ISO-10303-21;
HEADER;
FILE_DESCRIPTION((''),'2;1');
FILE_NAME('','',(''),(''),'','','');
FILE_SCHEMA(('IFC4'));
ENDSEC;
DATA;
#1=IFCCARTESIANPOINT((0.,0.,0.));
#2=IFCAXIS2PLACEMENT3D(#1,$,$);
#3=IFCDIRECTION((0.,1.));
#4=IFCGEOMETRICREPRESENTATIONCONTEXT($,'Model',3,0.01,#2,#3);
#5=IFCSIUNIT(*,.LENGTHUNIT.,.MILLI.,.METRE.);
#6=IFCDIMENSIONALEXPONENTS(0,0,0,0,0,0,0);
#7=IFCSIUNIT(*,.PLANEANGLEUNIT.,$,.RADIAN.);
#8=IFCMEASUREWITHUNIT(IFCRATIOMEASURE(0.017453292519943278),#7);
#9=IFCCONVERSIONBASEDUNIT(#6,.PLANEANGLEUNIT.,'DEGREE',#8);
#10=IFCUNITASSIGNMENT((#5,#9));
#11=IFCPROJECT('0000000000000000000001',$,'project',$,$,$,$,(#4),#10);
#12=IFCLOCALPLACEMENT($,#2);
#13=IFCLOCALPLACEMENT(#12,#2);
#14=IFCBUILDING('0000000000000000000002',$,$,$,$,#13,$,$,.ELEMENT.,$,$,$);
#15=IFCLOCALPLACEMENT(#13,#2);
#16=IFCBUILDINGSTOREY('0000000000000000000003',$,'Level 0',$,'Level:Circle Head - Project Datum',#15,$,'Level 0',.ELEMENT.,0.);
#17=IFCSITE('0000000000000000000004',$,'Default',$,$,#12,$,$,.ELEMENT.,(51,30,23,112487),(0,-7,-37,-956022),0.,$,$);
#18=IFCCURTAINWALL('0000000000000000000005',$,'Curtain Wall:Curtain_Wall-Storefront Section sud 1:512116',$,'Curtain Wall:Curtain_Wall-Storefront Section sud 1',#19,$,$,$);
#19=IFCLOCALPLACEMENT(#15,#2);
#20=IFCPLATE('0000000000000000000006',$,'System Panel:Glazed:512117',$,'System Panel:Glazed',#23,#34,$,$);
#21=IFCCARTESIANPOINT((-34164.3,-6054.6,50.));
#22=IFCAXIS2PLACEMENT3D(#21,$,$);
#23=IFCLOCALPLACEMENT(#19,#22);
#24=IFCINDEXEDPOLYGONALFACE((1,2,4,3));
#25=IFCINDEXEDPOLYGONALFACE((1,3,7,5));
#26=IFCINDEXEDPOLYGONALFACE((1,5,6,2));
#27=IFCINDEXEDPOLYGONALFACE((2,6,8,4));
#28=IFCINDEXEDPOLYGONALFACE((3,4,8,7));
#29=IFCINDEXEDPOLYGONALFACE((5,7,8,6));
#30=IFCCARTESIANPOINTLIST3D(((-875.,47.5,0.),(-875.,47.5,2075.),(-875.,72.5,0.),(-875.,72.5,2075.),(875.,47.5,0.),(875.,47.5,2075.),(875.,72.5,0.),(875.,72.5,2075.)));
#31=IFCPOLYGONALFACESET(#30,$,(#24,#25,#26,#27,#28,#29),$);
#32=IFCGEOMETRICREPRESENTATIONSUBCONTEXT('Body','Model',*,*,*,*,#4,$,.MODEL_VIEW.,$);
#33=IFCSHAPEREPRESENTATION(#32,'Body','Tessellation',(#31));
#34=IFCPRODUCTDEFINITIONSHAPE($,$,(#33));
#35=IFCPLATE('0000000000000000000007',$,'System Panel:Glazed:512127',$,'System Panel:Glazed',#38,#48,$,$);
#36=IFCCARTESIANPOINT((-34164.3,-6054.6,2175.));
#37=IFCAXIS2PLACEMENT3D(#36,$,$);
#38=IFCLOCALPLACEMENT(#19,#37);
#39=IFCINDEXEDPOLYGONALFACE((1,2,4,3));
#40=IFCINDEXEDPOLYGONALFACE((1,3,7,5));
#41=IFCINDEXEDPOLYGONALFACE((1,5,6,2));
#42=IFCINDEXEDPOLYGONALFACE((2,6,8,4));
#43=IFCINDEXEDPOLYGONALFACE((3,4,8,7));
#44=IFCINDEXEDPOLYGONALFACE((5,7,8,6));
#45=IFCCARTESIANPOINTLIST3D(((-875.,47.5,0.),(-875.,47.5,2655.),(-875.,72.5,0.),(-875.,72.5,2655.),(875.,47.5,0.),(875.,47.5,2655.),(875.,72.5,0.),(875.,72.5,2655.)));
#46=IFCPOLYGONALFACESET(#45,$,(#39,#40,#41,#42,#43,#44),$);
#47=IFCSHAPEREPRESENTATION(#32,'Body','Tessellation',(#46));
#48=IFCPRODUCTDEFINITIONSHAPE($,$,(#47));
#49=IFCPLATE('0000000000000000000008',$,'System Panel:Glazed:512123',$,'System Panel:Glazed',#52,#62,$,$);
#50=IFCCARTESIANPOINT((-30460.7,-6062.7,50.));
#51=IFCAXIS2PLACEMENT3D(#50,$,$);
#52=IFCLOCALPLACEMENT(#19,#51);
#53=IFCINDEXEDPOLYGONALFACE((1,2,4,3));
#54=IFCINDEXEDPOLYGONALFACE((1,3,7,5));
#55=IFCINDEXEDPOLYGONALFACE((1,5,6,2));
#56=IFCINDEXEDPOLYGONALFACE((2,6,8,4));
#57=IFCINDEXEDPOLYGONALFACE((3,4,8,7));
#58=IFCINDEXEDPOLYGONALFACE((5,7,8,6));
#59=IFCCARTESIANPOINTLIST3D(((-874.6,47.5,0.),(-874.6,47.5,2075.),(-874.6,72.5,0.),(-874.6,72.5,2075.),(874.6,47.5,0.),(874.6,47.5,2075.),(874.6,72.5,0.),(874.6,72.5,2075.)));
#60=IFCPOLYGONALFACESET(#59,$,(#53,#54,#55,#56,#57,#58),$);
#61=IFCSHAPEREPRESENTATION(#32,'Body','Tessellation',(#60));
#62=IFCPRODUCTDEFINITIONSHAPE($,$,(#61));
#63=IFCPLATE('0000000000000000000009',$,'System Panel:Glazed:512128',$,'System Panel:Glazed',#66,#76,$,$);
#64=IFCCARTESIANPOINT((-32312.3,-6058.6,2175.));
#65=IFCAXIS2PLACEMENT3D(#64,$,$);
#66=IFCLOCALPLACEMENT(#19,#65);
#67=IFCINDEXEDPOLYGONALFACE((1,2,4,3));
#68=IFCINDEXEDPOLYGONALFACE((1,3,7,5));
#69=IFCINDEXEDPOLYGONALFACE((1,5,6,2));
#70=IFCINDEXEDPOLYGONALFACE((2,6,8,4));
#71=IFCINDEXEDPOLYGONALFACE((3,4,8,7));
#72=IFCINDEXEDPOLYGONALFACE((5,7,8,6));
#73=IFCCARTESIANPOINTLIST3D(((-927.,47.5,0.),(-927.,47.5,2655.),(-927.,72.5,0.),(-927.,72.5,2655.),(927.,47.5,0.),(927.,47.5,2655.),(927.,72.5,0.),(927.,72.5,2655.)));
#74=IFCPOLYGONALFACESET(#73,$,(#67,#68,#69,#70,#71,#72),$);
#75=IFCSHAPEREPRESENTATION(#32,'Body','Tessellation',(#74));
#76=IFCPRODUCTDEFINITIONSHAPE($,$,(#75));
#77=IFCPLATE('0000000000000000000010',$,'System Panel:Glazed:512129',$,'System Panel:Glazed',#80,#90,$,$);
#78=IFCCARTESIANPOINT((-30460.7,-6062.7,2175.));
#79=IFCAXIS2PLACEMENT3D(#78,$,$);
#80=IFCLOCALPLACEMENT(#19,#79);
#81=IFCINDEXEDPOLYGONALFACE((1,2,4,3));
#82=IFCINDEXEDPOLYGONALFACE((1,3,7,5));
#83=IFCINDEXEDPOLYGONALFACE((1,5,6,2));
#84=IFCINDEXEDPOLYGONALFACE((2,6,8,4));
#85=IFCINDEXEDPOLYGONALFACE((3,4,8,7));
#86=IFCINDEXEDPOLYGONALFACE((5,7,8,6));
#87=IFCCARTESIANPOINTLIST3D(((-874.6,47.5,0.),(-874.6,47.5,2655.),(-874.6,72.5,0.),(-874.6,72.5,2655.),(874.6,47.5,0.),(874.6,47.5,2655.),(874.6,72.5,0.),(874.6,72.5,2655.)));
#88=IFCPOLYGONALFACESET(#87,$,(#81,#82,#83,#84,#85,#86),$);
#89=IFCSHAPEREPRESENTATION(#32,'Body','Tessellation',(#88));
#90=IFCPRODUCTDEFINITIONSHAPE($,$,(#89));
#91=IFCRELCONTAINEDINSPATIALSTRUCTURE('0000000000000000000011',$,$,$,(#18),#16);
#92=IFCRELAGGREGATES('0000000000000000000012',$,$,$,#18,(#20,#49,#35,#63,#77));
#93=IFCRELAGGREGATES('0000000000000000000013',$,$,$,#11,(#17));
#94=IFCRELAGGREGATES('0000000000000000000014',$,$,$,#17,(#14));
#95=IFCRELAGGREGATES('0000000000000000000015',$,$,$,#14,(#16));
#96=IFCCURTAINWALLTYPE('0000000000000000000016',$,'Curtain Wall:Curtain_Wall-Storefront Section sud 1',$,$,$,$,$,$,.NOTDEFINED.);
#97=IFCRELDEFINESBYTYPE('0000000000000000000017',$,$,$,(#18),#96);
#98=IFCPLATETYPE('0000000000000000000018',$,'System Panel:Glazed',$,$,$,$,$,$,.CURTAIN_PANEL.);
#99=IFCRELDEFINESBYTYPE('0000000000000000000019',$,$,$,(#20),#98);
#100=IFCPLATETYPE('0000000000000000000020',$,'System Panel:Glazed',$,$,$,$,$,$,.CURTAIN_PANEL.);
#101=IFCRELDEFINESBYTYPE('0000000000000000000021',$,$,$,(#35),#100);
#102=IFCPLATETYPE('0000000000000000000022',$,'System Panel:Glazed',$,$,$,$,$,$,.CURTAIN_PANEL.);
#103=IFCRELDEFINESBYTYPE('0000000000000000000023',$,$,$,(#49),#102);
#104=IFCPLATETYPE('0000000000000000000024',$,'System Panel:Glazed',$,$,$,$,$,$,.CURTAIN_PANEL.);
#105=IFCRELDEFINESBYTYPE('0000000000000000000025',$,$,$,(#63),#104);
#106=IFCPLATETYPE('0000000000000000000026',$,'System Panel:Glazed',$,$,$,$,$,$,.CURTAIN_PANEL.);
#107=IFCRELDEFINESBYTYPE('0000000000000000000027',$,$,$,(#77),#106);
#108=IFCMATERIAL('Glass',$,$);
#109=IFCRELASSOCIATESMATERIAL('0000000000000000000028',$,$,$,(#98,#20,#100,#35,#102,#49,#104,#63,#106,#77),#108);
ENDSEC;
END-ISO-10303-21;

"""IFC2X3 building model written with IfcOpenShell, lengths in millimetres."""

from ifc_helpers import new_model, entity, si_unit, converted_unit, direction, frame, frame_2d, origin, origin_2d_with_axis, place, context, subcontext, project, spatial, rectangle, extrude, source, transform, mapped, material, type_object, type_shapes, element, aggregate, save


model = new_model("IFC2X3")

# Units and contexts
model_context = context("Model", 3, precision=0.01, world=origin(), true_north=direction((0.0, 1.0)))
body_context = subcontext(model_context, "Body", "Model", "MODEL_VIEW")
ifc_project = project(units=[si_unit("LENGTHUNIT", "METRE", prefix="MILLI"), converted_unit("PLANEANGLEUNIT", "DEGREE", entity("IfcRatioMeasure", 0.017453292519943278), si_unit("PLANEANGLEUNIT", "RADIAN"), dimensions=[0, 0, 0, 0, 0, 0, 0])], contexts=[model_context])

# Site, building, storey
site_placement = place(None, origin())
site = spatial("IfcSite", under=ifc_project, at=site_placement, Name="Default", CompositionType="ELEMENT", RefLatitude=(51, 30, 23, 112487), RefLongitude=(0, -7, -37, -956022), RefElevation=0.0)
building_placement = place(site_placement, origin())
building = spatial("IfcBuilding", under=site, at=building_placement, CompositionType="ELEMENT")
storey_placement = place(building_placement, origin())
storey = spatial("IfcBuildingStorey", under=building, at=storey_placement, Name="Level 0", ObjectType="Level:Circle Head - Project Datum", LongName="Level 0", CompositionType="ELEMENT", Elevation=0.0)

# Curtain wall, plates
curtain_wall_type = type_object("IfcCurtainWallType", Name="Curtain Wall:Curtain_Wall-Storefront Section sud 1", PredefinedType="NOTDEFINED")
curtain_wall_placement = place(storey_placement, origin())
curtain_wall = element("IfcCurtainWall", 1, at=curtain_wall_placement, inside=storey, type_object=curtain_wall_type, Name="Curtain Wall:Curtain_Wall-Storefront Section sud 1:512116", ObjectType="Curtain Wall:Curtain_Wall-Storefront Section sud 1")
ifc_material_1 = material(Name="Glass")
plate_type_1 = type_object("IfcPlateType", Name="System Panel:Glazed", PredefinedType="CURTAIN_PANEL", material=ifc_material_1)
shared_shape_1 = source(origin(), body_context, "Body", "SweptSolid", [
    extrude(rectangle(XDim=25.0, YDim=1750.0, at=origin_2d_with_axis()), frame((0.0, 60.0, 0.0), z_axis=(0.0, 0.0, 1.0), x_axis=(0.0, 1.0, 0.0)), (0.0, 0.0, 1.0), 2075.0),
])
type_shapes(plate_type_1, [shared_shape_1])
plate_1_placement = place(curtain_wall_placement, frame((-34164.3, -6054.6, 50.0)))
plate_1 = element("IfcPlate", 2, at=plate_1_placement, type_object=plate_type_1, material=ifc_material_1, Name="System Panel:Glazed:512117", ObjectType="System Panel:Glazed", context=body_context, shape_type="MappedRepresentation", body=[
    mapped(shared_shape_1, transform((0.0, 0.0, 0.0), scale=1.0)),
])
plate_type_2 = type_object("IfcPlateType", Name="System Panel:Glazed", PredefinedType="CURTAIN_PANEL", material=ifc_material_1)
shared_shape_2 = source(origin(), body_context, "Body", "SweptSolid", [
    extrude(rectangle(XDim=25.0, YDim=1750.0, at=frame_2d((0.0, 0.0), x_axis=(1.0, 0.0))), frame((0.0, 60.0, 0.0), z_axis=(0.0, 0.0, 1.0), x_axis=(0.0, 1.0, 0.0)), (0.0, 0.0, 1.0), 2655.0),
])
type_shapes(plate_type_2, [shared_shape_2])
plate_2_placement = place(curtain_wall_placement, frame((-34164.3, -6054.6, 2175.0)))
plate_2 = element("IfcPlate", 3, at=plate_2_placement, type_object=plate_type_2, material=ifc_material_1, Name="System Panel:Glazed:512127", ObjectType="System Panel:Glazed", context=body_context, shape_type="MappedRepresentation", body=[
    mapped(shared_shape_2, transform((0.0, 0.0, 0.0), scale=1.0)),
])
plate_type_3 = type_object("IfcPlateType", Name="System Panel:Glazed", PredefinedType="CURTAIN_PANEL", material=ifc_material_1)
shared_shape_3 = source(origin(), body_context, "Body", "SweptSolid", [
    extrude(rectangle(XDim=25.0, YDim=1749.2, at=origin_2d_with_axis()), frame((0.0, 60.0, 0.0), z_axis=(0.0, 0.0, 1.0), x_axis=(0.0, 1.0, 0.0)), (0.0, 0.0, 1.0), 2075.0),
])
type_shapes(plate_type_3, [shared_shape_3])
plate_3_placement = place(curtain_wall_placement, frame((-30460.7, -6062.7, 50.0)))
plate_3 = element("IfcPlate", 4, at=plate_3_placement, type_object=plate_type_3, material=ifc_material_1, Name="System Panel:Glazed:512123", ObjectType="System Panel:Glazed", context=body_context, shape_type="MappedRepresentation", body=[
    mapped(shared_shape_3, transform((0.0, 0.0, 0.0), scale=1.0)),
])
plate_type_4 = type_object("IfcPlateType", Name="System Panel:Glazed", PredefinedType="CURTAIN_PANEL", material=ifc_material_1)
shared_shape_4 = source(origin(), body_context, "Body", "SweptSolid", [
    extrude(rectangle(XDim=25.0, YDim=1854.0, at=frame_2d((0.0, 0.0), x_axis=(1.0, 0.0))), frame((0.0, 60.0, 0.0), z_axis=(0.0, 0.0, 1.0), x_axis=(0.0, 1.0, 0.0)), (0.0, 0.0, 1.0), 2655.0),
])
type_shapes(plate_type_4, [shared_shape_4])
plate_4_placement = place(curtain_wall_placement, frame((-32312.3, -6058.6, 2175.0)))
plate_4 = element("IfcPlate", 5, at=plate_4_placement, type_object=plate_type_4, material=ifc_material_1, Name="System Panel:Glazed:512128", ObjectType="System Panel:Glazed", context=body_context, shape_type="MappedRepresentation", body=[
    mapped(shared_shape_4, transform((0.0, 0.0, 0.0), scale=1.0)),
])
plate_type_5 = type_object("IfcPlateType", Name="System Panel:Glazed", PredefinedType="CURTAIN_PANEL", material=ifc_material_1)
shared_shape_5 = source(origin(), body_context, "Body", "SweptSolid", [
    extrude(rectangle(XDim=25.0, YDim=1749.2, at=frame_2d((0.0, 0.0), x_axis=(1.0, 0.0))), frame((0.0, 60.0, 0.0), z_axis=(0.0, 0.0, 1.0), x_axis=(0.0, 1.0, 0.0)), (0.0, 0.0, 1.0), 2655.0),
])
type_shapes(plate_type_5, [shared_shape_5])
plate_5_placement = place(curtain_wall_placement, frame((-30460.7, -6062.7, 2175.0)))
plate_5 = element("IfcPlate", 6, at=plate_5_placement, type_object=plate_type_5, material=ifc_material_1, Name="System Panel:Glazed:512129", ObjectType="System Panel:Glazed", context=body_context, shape_type="MappedRepresentation", body=[
    mapped(shared_shape_5, transform((0.0, 0.0, 0.0), scale=1.0)),
])
aggregate(curtain_wall, [plate_1, plate_3, plate_2, plate_4, plate_5])

save(model, "model.ifc")
